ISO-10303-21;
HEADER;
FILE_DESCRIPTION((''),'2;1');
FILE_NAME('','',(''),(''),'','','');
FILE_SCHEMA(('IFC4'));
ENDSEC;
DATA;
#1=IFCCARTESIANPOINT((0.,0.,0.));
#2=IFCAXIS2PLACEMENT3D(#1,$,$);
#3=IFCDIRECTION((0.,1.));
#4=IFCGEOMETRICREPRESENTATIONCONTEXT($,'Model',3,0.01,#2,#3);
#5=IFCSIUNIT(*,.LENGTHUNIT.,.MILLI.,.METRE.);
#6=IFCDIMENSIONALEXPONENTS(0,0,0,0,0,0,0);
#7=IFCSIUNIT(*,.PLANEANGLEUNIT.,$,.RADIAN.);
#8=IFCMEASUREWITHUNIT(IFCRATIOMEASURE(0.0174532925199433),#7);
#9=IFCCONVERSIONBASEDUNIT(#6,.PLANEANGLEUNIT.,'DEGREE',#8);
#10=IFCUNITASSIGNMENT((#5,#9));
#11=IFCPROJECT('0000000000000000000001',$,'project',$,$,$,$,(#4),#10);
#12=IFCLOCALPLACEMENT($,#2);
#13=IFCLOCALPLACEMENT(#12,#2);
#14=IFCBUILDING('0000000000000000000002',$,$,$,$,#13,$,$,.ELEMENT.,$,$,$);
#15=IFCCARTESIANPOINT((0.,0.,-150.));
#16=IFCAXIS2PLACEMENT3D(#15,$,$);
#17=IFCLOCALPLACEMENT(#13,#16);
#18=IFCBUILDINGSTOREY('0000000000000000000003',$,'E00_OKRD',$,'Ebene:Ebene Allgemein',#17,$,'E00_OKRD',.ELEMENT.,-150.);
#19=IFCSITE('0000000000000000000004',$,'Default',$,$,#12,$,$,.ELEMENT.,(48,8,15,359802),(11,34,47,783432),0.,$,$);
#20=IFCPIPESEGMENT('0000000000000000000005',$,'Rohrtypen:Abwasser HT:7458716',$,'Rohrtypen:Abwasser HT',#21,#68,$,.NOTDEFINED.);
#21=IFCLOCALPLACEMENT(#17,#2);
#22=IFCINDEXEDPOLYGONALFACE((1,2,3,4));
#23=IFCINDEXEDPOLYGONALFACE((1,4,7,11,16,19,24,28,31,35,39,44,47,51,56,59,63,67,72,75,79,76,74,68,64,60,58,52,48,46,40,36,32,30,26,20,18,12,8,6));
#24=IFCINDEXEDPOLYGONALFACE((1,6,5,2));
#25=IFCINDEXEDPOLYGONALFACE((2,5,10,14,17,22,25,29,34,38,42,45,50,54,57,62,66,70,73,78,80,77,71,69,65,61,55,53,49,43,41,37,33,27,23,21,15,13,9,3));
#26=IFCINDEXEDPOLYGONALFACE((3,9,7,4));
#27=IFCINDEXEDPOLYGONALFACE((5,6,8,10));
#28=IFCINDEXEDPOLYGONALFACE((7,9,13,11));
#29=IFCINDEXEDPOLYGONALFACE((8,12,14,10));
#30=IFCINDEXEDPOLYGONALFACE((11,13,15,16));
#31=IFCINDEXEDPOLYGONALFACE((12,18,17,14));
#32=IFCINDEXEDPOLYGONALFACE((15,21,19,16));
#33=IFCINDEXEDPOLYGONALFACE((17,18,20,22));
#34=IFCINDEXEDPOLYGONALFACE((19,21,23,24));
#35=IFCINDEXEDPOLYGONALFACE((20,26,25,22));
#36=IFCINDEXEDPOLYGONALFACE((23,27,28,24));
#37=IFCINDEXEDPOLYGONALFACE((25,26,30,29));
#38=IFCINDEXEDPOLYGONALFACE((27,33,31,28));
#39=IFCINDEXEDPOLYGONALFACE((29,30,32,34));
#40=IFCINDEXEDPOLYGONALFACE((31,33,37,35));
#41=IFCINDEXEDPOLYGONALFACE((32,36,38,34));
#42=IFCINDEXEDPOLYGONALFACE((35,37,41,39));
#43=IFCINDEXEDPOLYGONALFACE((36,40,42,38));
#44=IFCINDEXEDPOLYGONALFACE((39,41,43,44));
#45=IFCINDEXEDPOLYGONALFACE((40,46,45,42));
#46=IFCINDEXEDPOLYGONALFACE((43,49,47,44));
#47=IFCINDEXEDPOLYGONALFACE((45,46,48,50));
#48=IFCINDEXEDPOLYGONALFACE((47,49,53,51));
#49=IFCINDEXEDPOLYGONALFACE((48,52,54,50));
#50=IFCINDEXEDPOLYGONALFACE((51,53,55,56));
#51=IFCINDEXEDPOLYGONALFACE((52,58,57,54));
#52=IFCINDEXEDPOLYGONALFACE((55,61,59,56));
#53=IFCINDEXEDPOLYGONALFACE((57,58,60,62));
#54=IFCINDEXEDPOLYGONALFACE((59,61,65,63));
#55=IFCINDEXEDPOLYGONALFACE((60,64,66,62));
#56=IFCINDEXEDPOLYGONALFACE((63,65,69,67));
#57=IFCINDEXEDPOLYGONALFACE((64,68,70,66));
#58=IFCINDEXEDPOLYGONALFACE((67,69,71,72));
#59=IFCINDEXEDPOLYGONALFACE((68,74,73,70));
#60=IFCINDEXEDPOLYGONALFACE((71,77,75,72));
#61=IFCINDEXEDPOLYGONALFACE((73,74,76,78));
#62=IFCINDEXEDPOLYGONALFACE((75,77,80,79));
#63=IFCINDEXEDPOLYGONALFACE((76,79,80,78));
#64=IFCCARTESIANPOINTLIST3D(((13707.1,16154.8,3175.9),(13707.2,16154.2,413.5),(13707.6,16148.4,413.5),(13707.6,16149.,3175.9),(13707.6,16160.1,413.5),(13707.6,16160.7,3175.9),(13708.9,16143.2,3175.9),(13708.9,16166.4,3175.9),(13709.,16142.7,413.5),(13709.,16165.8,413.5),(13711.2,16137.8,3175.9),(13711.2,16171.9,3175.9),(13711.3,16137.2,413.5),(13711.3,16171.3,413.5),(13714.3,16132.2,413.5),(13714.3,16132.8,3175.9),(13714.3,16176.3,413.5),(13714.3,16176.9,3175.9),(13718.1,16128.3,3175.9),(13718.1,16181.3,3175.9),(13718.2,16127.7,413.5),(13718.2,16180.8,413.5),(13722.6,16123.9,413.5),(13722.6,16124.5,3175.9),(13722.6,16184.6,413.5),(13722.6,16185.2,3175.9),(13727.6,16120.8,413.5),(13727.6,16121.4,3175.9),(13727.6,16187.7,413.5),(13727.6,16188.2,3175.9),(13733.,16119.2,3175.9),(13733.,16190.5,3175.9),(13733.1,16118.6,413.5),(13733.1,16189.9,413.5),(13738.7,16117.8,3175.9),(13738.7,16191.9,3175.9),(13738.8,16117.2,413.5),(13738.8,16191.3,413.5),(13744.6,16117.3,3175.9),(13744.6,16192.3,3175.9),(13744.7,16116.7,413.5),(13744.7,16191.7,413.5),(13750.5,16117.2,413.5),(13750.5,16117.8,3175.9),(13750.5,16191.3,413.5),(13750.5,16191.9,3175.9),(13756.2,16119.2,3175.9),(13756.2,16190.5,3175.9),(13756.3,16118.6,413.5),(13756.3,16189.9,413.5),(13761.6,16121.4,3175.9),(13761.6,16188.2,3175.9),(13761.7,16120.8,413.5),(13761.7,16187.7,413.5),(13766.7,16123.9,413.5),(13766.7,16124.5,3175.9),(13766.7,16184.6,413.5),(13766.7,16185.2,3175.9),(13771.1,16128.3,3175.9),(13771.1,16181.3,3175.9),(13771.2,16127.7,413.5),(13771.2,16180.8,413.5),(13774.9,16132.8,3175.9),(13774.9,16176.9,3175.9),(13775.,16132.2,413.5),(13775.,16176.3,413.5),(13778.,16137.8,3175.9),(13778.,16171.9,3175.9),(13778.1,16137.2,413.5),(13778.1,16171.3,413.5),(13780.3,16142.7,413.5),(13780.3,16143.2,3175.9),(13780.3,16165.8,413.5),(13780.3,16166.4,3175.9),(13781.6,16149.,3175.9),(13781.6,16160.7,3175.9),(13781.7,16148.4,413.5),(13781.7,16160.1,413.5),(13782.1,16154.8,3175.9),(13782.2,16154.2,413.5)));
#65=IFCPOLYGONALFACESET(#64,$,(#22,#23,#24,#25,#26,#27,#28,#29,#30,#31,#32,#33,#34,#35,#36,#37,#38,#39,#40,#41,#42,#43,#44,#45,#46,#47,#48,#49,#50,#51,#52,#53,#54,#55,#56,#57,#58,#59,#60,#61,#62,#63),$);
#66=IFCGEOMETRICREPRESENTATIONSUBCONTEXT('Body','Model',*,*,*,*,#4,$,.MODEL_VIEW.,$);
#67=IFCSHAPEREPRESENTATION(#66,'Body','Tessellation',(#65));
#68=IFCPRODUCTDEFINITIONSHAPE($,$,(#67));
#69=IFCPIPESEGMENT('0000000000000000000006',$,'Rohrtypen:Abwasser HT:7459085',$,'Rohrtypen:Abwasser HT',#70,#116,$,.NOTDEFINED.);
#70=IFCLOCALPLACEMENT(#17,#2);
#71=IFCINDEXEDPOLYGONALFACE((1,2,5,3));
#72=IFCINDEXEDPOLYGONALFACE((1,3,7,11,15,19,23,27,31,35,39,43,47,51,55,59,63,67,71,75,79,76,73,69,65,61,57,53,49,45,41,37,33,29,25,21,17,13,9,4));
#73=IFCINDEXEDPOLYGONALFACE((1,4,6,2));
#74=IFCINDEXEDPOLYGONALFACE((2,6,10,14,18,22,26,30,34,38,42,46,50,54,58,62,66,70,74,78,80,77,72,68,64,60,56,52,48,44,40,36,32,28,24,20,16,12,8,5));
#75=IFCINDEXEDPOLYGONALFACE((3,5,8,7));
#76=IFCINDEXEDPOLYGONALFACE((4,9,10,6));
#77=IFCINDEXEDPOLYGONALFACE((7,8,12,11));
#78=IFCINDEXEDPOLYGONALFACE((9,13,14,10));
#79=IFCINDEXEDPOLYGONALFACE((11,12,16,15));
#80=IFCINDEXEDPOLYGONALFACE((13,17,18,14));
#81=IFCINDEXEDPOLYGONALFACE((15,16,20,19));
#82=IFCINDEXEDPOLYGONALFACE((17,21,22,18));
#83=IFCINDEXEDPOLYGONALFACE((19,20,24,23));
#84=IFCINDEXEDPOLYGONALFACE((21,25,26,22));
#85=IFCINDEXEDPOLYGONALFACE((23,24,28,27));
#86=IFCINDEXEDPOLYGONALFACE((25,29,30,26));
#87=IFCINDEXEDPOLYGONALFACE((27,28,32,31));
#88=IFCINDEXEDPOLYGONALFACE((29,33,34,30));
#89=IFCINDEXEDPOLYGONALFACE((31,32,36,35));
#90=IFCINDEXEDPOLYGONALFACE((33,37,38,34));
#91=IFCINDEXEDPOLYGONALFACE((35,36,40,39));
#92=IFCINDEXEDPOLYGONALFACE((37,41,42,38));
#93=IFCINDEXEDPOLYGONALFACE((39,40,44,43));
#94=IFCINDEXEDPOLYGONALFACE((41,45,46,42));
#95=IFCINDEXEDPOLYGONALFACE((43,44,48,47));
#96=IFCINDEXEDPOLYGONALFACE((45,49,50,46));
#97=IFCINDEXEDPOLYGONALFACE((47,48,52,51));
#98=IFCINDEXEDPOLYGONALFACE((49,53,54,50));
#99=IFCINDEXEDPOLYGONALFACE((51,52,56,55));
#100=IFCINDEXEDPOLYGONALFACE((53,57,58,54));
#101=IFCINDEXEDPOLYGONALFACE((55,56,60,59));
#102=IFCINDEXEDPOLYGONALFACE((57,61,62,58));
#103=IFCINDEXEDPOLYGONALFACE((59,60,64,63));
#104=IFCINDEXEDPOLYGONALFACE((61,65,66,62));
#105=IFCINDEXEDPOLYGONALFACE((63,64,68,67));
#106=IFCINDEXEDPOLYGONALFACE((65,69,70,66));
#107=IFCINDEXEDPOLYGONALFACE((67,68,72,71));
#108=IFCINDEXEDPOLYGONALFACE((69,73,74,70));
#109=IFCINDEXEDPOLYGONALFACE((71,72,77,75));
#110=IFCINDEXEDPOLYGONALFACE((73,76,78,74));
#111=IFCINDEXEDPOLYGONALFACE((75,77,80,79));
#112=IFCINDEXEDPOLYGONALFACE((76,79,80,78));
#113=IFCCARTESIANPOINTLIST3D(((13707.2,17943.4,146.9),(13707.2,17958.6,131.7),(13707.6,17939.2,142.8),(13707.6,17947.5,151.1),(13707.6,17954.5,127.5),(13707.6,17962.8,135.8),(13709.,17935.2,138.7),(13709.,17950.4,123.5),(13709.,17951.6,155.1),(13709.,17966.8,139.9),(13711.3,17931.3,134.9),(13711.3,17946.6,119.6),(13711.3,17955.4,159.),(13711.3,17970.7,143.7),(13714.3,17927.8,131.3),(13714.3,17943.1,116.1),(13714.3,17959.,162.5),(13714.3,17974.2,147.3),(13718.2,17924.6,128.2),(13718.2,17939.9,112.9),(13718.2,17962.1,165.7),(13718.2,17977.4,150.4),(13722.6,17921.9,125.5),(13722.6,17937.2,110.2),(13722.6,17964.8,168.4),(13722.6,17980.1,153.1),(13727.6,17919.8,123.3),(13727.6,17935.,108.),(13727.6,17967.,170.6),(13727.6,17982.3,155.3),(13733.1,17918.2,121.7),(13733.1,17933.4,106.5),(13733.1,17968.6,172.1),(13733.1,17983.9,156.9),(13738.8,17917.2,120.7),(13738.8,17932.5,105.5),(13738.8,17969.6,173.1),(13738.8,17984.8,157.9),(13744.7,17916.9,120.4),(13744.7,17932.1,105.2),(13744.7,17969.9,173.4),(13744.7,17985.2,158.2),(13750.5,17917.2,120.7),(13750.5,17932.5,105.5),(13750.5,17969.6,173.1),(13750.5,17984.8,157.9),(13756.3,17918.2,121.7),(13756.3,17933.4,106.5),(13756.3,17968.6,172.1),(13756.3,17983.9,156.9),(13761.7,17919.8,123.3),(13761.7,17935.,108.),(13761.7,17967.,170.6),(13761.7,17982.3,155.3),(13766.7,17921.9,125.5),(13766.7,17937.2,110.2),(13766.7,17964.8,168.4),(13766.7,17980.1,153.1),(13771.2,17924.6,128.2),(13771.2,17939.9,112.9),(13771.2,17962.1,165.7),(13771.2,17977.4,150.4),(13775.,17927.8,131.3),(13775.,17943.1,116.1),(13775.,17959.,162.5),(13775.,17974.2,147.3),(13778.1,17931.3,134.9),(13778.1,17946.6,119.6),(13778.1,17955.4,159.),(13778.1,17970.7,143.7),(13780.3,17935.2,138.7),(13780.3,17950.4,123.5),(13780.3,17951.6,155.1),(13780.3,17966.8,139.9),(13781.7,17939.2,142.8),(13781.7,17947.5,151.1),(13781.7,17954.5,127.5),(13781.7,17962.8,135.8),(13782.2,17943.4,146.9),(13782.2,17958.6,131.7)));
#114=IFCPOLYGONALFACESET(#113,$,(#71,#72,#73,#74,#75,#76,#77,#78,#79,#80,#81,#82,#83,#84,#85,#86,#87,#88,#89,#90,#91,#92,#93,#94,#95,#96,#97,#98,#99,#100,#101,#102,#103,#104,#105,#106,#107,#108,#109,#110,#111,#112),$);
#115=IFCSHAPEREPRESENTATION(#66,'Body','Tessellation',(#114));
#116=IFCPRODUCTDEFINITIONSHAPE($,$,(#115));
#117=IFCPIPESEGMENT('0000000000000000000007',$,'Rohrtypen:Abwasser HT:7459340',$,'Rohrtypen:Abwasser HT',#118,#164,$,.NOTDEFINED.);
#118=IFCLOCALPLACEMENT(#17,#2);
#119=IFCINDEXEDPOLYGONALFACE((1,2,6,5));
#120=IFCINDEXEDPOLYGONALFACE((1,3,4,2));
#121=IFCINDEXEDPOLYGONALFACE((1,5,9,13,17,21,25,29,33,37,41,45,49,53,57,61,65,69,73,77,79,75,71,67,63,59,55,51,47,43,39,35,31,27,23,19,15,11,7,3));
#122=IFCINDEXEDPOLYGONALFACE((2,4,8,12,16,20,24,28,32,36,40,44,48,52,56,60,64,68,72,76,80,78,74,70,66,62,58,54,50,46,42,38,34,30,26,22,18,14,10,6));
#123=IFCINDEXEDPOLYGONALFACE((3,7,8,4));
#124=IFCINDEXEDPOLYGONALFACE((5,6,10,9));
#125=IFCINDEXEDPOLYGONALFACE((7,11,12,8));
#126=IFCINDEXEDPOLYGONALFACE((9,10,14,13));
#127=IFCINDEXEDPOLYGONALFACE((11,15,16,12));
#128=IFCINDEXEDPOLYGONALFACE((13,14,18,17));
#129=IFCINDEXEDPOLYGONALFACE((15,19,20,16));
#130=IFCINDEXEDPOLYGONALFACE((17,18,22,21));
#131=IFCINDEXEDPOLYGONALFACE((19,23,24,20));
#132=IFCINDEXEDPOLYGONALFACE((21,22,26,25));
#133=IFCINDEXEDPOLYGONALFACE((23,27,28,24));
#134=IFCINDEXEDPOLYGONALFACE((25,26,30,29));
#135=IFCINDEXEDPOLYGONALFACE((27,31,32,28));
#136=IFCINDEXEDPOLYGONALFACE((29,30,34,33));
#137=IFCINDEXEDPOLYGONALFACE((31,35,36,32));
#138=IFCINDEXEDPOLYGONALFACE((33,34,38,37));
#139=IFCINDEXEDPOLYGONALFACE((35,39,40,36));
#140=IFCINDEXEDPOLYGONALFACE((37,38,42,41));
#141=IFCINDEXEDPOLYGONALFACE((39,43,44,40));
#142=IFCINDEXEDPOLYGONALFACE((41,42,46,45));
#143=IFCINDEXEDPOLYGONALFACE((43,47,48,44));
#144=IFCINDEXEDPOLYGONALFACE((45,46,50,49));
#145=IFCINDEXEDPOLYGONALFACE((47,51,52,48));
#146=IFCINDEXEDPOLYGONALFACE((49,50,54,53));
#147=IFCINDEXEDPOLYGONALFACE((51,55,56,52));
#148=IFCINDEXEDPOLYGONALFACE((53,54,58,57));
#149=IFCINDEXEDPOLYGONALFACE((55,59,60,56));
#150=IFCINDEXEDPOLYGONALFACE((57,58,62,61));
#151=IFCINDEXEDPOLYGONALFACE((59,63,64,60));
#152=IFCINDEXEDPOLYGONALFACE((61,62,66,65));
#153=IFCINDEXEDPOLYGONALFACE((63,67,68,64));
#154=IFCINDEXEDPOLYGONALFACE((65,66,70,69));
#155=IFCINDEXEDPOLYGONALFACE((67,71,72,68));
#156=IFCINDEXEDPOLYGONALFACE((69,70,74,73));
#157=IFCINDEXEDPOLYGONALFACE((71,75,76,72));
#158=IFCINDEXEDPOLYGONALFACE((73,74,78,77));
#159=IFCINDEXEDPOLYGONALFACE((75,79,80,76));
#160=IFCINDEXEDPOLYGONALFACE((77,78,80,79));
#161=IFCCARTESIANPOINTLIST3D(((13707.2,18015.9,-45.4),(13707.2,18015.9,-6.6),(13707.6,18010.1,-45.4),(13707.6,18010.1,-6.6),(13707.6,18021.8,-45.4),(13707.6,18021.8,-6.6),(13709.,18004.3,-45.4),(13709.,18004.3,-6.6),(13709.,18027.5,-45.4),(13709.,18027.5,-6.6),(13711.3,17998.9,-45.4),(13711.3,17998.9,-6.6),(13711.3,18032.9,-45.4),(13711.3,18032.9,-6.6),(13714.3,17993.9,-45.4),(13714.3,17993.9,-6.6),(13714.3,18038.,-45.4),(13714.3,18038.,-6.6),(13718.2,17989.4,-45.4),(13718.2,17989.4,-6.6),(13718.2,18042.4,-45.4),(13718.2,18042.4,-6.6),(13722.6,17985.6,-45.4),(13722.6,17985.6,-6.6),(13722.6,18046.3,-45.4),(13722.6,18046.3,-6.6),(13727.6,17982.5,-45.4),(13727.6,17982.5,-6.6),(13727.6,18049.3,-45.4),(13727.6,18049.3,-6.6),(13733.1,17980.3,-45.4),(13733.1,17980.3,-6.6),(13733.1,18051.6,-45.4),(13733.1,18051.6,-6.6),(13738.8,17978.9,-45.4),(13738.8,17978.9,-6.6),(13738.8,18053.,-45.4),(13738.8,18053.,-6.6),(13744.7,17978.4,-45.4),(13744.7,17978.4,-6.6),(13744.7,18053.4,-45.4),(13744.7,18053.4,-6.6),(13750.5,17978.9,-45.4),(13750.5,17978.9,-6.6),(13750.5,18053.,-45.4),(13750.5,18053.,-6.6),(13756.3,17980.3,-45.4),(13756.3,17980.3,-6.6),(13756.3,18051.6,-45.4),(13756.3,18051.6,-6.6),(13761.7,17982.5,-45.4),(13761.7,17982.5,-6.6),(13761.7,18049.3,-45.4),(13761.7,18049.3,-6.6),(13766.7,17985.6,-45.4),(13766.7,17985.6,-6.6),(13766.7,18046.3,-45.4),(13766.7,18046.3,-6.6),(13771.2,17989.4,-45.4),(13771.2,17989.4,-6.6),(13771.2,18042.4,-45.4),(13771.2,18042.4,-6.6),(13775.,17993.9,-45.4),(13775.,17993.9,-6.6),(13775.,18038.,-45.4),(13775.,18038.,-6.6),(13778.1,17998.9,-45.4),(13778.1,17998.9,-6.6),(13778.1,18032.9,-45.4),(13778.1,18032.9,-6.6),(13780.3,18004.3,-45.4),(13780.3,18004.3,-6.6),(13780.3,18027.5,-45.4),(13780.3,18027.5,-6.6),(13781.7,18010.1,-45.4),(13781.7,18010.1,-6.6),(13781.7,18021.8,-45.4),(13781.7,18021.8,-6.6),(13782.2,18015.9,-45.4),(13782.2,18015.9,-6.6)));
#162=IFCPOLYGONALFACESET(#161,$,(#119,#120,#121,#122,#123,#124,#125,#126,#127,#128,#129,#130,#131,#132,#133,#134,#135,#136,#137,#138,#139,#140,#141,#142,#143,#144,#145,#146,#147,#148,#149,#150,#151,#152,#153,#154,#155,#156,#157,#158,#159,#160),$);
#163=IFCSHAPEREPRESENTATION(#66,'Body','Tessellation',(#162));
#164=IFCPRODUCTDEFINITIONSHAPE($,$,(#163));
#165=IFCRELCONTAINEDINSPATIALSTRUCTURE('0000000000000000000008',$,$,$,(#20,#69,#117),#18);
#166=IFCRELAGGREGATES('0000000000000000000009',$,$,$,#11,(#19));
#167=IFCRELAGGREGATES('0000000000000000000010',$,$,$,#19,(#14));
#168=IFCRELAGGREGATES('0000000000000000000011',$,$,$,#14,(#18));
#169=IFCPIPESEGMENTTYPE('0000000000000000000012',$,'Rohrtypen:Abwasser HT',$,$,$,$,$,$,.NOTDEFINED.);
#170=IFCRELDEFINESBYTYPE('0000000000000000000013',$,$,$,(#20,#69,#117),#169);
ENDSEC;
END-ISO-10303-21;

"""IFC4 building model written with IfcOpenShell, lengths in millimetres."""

from ifc_helpers import new_model, entity, si_unit, converted_unit, direction, frame, origin, place, context, subcontext, project, spatial, indexed_curve, outline, extrude, type_object, element, save


model = new_model("IFC4")

# Units and contexts
model_context = context("Model", 3, precision=0.01, world=origin(), true_north=direction((0.0, 1.0)))
body_context = subcontext(model_context, "Body", "Model", "MODEL_VIEW")
ifc_project = project(units=[si_unit("LENGTHUNIT", "METRE", prefix="MILLI"), converted_unit("PLANEANGLEUNIT", "DEGREE", entity("IfcRatioMeasure", 0.0174532925199433), si_unit("PLANEANGLEUNIT", "RADIAN"), dimensions=[0, 0, 0, 0, 0, 0, 0])], contexts=[model_context])

# Site, building, storey
site_placement = place(None, origin())
site = spatial("IfcSite", under=ifc_project, at=site_placement, Name="Default", CompositionType="ELEMENT", RefLatitude=(48, 8, 15, 359802), RefLongitude=(11, 34, 47, 783432), RefElevation=0.0)
building_placement = place(site_placement, origin())
building = spatial("IfcBuilding", under=site, at=building_placement, CompositionType="ELEMENT")
storey_placement = place(building_placement, frame((0.0, 0.0, -150.0)))
storey = spatial("IfcBuildingStorey", under=building, at=storey_placement, Name="E00_OKRD", ObjectType="Ebene:Ebene Allgemein", LongName="E00_OKRD", CompositionType="ELEMENT", Elevation=-150.0)

# Pipe segments
pipe_segment_type_1 = type_object("IfcPipeSegmentType", Name="Rohrtypen:Abwasser HT", PredefinedType="NOTDEFINED")
pipe_segment_1_placement = place(storey_placement, origin())
element("IfcPipeSegment", 1, at=pipe_segment_1_placement, inside=storey, type_object=pipe_segment_type_1, Name="Rohrtypen:Abwasser HT:7458716", ObjectType="Rohrtypen:Abwasser HT", PredefinedType="NOTDEFINED", context=body_context, shape_type="SweptSolid", body=[
    extrude(outline(indexed_curve([(37.5, 0.0), (37.0, 5.9), (35.7, 11.6), (33.4, 17.0), (30.3, 22.0), (26.5, 26.5), (22.0, 30.3), (17.0, 33.4), (11.6, 35.7), (5.9, 37.0), (0.0, 37.5), (-5.9, 37.0), (-11.6, 35.7), (-17.0, 33.4), (-22.0, 30.3), (-26.5, 26.5), (-30.3, 22.0), (-33.4, 17.0), (-35.7, 11.6), (-37.0, 5.9), (-37.5, 0.0), (-37.0, -5.9), (-35.7, -11.6), (-33.4, -17.0), (-30.3, -22.0), (-26.5, -26.5), (-22.0, -30.3), (-17.0, -33.4), (-11.6, -35.7), (-5.9, -37.0), (0.0, -37.5), (5.9, -37.0), (11.6, -35.7), (17.0, -33.4), (22.0, -30.3), (26.5, -26.5), (30.3, -22.0), (33.4, -17.0), (35.7, -11.6), (37.0, -5.9), (37.5, 0.0)], self_intersect=False)), frame((13744.7, 16154.2, 413.5), z_axis=(-0.000022, 0.000214, 1.0), x_axis=(-1.0, 0.0, -0.000022)), (0.0, 0.0, 1.0), 2762.4),
])
pipe_segment_2_placement = place(storey_placement, origin())
element("IfcPipeSegment", 2, at=pipe_segment_2_placement, inside=storey, type_object=pipe_segment_type_1, Name="Rohrtypen:Abwasser HT:7459085", ObjectType="Rohrtypen:Abwasser HT", PredefinedType="NOTDEFINED", context=body_context, shape_type="SweptSolid", body=[
    extrude(outline(indexed_curve([(37.5, 0.0), (37.0, 5.9), (35.7, 11.6), (33.4, 17.0), (30.3, 22.0), (26.5, 26.5), (22.0, 30.3), (17.0, 33.4), (11.6, 35.7), (5.9, 37.0), (0.0, 37.5), (-5.9, 37.0), (-11.6, 35.7), (-17.0, 33.4), (-22.0, 30.3), (-26.5, 26.5), (-30.3, 22.0), (-33.4, 17.0), (-35.7, 11.6), (-37.0, 5.9), (-37.5, 0.0), (-37.0, -5.9), (-35.7, -11.6), (-33.4, -17.0), (-30.3, -22.0), (-26.5, -26.5), (-22.0, -30.3), (-17.0, -33.4), (-11.6, -35.7), (-5.9, -37.0), (0.0, -37.5), (5.9, -37.0), (11.6, -35.7), (17.0, -33.4), (22.0, -30.3), (26.5, -26.5), (30.3, -22.0), (33.4, -17.0), (35.7, -11.6), (37.0, -5.9), (37.5, 0.0)], self_intersect=False)), frame((13744.7, 17958.6, 131.7), z_axis=(0.0, -0.707107, 0.707107), x_axis=(1.0, 0.0, 0.0)), (0.0, 0.0, 1.0), 21.6),
])
pipe_segment_3_placement = place(storey_placement, origin())
element("IfcPipeSegment", 3, at=pipe_segment_3_placement, inside=storey, type_object=pipe_segment_type_1, Name="Rohrtypen:Abwasser HT:7459340", ObjectType="Rohrtypen:Abwasser HT", PredefinedType="NOTDEFINED", context=body_context, shape_type="SweptSolid", body=[
    extrude(outline(indexed_curve([(37.5, 0.0), (37.0, 5.9), (35.7, 11.6), (33.4, 17.0), (30.3, 22.0), (26.5, 26.5), (22.0, 30.3), (17.0, 33.4), (11.6, 35.7), (5.9, 37.0), (0.0, 37.5), (-5.9, 37.0), (-11.6, 35.7), (-17.0, 33.4), (-22.0, 30.3), (-26.5, 26.5), (-30.3, 22.0), (-33.4, 17.0), (-35.7, 11.6), (-37.0, 5.9), (-37.5, 0.0), (-37.0, -5.9), (-35.7, -11.6), (-33.4, -17.0), (-30.3, -22.0), (-26.5, -26.5), (-22.0, -30.3), (-17.0, -33.4), (-11.6, -35.7), (-5.9, -37.0), (0.0, -37.5), (5.9, -37.0), (11.6, -35.7), (17.0, -33.4), (22.0, -30.3), (26.5, -26.5), (30.3, -22.0), (33.4, -17.0), (35.7, -11.6), (37.0, -5.9), (37.5, 0.0)], self_intersect=False)), frame((13744.7, 18015.9, -45.4)), (0.0, 0.0, 1.0), 38.8),
])

save(model, "model.ifc")
